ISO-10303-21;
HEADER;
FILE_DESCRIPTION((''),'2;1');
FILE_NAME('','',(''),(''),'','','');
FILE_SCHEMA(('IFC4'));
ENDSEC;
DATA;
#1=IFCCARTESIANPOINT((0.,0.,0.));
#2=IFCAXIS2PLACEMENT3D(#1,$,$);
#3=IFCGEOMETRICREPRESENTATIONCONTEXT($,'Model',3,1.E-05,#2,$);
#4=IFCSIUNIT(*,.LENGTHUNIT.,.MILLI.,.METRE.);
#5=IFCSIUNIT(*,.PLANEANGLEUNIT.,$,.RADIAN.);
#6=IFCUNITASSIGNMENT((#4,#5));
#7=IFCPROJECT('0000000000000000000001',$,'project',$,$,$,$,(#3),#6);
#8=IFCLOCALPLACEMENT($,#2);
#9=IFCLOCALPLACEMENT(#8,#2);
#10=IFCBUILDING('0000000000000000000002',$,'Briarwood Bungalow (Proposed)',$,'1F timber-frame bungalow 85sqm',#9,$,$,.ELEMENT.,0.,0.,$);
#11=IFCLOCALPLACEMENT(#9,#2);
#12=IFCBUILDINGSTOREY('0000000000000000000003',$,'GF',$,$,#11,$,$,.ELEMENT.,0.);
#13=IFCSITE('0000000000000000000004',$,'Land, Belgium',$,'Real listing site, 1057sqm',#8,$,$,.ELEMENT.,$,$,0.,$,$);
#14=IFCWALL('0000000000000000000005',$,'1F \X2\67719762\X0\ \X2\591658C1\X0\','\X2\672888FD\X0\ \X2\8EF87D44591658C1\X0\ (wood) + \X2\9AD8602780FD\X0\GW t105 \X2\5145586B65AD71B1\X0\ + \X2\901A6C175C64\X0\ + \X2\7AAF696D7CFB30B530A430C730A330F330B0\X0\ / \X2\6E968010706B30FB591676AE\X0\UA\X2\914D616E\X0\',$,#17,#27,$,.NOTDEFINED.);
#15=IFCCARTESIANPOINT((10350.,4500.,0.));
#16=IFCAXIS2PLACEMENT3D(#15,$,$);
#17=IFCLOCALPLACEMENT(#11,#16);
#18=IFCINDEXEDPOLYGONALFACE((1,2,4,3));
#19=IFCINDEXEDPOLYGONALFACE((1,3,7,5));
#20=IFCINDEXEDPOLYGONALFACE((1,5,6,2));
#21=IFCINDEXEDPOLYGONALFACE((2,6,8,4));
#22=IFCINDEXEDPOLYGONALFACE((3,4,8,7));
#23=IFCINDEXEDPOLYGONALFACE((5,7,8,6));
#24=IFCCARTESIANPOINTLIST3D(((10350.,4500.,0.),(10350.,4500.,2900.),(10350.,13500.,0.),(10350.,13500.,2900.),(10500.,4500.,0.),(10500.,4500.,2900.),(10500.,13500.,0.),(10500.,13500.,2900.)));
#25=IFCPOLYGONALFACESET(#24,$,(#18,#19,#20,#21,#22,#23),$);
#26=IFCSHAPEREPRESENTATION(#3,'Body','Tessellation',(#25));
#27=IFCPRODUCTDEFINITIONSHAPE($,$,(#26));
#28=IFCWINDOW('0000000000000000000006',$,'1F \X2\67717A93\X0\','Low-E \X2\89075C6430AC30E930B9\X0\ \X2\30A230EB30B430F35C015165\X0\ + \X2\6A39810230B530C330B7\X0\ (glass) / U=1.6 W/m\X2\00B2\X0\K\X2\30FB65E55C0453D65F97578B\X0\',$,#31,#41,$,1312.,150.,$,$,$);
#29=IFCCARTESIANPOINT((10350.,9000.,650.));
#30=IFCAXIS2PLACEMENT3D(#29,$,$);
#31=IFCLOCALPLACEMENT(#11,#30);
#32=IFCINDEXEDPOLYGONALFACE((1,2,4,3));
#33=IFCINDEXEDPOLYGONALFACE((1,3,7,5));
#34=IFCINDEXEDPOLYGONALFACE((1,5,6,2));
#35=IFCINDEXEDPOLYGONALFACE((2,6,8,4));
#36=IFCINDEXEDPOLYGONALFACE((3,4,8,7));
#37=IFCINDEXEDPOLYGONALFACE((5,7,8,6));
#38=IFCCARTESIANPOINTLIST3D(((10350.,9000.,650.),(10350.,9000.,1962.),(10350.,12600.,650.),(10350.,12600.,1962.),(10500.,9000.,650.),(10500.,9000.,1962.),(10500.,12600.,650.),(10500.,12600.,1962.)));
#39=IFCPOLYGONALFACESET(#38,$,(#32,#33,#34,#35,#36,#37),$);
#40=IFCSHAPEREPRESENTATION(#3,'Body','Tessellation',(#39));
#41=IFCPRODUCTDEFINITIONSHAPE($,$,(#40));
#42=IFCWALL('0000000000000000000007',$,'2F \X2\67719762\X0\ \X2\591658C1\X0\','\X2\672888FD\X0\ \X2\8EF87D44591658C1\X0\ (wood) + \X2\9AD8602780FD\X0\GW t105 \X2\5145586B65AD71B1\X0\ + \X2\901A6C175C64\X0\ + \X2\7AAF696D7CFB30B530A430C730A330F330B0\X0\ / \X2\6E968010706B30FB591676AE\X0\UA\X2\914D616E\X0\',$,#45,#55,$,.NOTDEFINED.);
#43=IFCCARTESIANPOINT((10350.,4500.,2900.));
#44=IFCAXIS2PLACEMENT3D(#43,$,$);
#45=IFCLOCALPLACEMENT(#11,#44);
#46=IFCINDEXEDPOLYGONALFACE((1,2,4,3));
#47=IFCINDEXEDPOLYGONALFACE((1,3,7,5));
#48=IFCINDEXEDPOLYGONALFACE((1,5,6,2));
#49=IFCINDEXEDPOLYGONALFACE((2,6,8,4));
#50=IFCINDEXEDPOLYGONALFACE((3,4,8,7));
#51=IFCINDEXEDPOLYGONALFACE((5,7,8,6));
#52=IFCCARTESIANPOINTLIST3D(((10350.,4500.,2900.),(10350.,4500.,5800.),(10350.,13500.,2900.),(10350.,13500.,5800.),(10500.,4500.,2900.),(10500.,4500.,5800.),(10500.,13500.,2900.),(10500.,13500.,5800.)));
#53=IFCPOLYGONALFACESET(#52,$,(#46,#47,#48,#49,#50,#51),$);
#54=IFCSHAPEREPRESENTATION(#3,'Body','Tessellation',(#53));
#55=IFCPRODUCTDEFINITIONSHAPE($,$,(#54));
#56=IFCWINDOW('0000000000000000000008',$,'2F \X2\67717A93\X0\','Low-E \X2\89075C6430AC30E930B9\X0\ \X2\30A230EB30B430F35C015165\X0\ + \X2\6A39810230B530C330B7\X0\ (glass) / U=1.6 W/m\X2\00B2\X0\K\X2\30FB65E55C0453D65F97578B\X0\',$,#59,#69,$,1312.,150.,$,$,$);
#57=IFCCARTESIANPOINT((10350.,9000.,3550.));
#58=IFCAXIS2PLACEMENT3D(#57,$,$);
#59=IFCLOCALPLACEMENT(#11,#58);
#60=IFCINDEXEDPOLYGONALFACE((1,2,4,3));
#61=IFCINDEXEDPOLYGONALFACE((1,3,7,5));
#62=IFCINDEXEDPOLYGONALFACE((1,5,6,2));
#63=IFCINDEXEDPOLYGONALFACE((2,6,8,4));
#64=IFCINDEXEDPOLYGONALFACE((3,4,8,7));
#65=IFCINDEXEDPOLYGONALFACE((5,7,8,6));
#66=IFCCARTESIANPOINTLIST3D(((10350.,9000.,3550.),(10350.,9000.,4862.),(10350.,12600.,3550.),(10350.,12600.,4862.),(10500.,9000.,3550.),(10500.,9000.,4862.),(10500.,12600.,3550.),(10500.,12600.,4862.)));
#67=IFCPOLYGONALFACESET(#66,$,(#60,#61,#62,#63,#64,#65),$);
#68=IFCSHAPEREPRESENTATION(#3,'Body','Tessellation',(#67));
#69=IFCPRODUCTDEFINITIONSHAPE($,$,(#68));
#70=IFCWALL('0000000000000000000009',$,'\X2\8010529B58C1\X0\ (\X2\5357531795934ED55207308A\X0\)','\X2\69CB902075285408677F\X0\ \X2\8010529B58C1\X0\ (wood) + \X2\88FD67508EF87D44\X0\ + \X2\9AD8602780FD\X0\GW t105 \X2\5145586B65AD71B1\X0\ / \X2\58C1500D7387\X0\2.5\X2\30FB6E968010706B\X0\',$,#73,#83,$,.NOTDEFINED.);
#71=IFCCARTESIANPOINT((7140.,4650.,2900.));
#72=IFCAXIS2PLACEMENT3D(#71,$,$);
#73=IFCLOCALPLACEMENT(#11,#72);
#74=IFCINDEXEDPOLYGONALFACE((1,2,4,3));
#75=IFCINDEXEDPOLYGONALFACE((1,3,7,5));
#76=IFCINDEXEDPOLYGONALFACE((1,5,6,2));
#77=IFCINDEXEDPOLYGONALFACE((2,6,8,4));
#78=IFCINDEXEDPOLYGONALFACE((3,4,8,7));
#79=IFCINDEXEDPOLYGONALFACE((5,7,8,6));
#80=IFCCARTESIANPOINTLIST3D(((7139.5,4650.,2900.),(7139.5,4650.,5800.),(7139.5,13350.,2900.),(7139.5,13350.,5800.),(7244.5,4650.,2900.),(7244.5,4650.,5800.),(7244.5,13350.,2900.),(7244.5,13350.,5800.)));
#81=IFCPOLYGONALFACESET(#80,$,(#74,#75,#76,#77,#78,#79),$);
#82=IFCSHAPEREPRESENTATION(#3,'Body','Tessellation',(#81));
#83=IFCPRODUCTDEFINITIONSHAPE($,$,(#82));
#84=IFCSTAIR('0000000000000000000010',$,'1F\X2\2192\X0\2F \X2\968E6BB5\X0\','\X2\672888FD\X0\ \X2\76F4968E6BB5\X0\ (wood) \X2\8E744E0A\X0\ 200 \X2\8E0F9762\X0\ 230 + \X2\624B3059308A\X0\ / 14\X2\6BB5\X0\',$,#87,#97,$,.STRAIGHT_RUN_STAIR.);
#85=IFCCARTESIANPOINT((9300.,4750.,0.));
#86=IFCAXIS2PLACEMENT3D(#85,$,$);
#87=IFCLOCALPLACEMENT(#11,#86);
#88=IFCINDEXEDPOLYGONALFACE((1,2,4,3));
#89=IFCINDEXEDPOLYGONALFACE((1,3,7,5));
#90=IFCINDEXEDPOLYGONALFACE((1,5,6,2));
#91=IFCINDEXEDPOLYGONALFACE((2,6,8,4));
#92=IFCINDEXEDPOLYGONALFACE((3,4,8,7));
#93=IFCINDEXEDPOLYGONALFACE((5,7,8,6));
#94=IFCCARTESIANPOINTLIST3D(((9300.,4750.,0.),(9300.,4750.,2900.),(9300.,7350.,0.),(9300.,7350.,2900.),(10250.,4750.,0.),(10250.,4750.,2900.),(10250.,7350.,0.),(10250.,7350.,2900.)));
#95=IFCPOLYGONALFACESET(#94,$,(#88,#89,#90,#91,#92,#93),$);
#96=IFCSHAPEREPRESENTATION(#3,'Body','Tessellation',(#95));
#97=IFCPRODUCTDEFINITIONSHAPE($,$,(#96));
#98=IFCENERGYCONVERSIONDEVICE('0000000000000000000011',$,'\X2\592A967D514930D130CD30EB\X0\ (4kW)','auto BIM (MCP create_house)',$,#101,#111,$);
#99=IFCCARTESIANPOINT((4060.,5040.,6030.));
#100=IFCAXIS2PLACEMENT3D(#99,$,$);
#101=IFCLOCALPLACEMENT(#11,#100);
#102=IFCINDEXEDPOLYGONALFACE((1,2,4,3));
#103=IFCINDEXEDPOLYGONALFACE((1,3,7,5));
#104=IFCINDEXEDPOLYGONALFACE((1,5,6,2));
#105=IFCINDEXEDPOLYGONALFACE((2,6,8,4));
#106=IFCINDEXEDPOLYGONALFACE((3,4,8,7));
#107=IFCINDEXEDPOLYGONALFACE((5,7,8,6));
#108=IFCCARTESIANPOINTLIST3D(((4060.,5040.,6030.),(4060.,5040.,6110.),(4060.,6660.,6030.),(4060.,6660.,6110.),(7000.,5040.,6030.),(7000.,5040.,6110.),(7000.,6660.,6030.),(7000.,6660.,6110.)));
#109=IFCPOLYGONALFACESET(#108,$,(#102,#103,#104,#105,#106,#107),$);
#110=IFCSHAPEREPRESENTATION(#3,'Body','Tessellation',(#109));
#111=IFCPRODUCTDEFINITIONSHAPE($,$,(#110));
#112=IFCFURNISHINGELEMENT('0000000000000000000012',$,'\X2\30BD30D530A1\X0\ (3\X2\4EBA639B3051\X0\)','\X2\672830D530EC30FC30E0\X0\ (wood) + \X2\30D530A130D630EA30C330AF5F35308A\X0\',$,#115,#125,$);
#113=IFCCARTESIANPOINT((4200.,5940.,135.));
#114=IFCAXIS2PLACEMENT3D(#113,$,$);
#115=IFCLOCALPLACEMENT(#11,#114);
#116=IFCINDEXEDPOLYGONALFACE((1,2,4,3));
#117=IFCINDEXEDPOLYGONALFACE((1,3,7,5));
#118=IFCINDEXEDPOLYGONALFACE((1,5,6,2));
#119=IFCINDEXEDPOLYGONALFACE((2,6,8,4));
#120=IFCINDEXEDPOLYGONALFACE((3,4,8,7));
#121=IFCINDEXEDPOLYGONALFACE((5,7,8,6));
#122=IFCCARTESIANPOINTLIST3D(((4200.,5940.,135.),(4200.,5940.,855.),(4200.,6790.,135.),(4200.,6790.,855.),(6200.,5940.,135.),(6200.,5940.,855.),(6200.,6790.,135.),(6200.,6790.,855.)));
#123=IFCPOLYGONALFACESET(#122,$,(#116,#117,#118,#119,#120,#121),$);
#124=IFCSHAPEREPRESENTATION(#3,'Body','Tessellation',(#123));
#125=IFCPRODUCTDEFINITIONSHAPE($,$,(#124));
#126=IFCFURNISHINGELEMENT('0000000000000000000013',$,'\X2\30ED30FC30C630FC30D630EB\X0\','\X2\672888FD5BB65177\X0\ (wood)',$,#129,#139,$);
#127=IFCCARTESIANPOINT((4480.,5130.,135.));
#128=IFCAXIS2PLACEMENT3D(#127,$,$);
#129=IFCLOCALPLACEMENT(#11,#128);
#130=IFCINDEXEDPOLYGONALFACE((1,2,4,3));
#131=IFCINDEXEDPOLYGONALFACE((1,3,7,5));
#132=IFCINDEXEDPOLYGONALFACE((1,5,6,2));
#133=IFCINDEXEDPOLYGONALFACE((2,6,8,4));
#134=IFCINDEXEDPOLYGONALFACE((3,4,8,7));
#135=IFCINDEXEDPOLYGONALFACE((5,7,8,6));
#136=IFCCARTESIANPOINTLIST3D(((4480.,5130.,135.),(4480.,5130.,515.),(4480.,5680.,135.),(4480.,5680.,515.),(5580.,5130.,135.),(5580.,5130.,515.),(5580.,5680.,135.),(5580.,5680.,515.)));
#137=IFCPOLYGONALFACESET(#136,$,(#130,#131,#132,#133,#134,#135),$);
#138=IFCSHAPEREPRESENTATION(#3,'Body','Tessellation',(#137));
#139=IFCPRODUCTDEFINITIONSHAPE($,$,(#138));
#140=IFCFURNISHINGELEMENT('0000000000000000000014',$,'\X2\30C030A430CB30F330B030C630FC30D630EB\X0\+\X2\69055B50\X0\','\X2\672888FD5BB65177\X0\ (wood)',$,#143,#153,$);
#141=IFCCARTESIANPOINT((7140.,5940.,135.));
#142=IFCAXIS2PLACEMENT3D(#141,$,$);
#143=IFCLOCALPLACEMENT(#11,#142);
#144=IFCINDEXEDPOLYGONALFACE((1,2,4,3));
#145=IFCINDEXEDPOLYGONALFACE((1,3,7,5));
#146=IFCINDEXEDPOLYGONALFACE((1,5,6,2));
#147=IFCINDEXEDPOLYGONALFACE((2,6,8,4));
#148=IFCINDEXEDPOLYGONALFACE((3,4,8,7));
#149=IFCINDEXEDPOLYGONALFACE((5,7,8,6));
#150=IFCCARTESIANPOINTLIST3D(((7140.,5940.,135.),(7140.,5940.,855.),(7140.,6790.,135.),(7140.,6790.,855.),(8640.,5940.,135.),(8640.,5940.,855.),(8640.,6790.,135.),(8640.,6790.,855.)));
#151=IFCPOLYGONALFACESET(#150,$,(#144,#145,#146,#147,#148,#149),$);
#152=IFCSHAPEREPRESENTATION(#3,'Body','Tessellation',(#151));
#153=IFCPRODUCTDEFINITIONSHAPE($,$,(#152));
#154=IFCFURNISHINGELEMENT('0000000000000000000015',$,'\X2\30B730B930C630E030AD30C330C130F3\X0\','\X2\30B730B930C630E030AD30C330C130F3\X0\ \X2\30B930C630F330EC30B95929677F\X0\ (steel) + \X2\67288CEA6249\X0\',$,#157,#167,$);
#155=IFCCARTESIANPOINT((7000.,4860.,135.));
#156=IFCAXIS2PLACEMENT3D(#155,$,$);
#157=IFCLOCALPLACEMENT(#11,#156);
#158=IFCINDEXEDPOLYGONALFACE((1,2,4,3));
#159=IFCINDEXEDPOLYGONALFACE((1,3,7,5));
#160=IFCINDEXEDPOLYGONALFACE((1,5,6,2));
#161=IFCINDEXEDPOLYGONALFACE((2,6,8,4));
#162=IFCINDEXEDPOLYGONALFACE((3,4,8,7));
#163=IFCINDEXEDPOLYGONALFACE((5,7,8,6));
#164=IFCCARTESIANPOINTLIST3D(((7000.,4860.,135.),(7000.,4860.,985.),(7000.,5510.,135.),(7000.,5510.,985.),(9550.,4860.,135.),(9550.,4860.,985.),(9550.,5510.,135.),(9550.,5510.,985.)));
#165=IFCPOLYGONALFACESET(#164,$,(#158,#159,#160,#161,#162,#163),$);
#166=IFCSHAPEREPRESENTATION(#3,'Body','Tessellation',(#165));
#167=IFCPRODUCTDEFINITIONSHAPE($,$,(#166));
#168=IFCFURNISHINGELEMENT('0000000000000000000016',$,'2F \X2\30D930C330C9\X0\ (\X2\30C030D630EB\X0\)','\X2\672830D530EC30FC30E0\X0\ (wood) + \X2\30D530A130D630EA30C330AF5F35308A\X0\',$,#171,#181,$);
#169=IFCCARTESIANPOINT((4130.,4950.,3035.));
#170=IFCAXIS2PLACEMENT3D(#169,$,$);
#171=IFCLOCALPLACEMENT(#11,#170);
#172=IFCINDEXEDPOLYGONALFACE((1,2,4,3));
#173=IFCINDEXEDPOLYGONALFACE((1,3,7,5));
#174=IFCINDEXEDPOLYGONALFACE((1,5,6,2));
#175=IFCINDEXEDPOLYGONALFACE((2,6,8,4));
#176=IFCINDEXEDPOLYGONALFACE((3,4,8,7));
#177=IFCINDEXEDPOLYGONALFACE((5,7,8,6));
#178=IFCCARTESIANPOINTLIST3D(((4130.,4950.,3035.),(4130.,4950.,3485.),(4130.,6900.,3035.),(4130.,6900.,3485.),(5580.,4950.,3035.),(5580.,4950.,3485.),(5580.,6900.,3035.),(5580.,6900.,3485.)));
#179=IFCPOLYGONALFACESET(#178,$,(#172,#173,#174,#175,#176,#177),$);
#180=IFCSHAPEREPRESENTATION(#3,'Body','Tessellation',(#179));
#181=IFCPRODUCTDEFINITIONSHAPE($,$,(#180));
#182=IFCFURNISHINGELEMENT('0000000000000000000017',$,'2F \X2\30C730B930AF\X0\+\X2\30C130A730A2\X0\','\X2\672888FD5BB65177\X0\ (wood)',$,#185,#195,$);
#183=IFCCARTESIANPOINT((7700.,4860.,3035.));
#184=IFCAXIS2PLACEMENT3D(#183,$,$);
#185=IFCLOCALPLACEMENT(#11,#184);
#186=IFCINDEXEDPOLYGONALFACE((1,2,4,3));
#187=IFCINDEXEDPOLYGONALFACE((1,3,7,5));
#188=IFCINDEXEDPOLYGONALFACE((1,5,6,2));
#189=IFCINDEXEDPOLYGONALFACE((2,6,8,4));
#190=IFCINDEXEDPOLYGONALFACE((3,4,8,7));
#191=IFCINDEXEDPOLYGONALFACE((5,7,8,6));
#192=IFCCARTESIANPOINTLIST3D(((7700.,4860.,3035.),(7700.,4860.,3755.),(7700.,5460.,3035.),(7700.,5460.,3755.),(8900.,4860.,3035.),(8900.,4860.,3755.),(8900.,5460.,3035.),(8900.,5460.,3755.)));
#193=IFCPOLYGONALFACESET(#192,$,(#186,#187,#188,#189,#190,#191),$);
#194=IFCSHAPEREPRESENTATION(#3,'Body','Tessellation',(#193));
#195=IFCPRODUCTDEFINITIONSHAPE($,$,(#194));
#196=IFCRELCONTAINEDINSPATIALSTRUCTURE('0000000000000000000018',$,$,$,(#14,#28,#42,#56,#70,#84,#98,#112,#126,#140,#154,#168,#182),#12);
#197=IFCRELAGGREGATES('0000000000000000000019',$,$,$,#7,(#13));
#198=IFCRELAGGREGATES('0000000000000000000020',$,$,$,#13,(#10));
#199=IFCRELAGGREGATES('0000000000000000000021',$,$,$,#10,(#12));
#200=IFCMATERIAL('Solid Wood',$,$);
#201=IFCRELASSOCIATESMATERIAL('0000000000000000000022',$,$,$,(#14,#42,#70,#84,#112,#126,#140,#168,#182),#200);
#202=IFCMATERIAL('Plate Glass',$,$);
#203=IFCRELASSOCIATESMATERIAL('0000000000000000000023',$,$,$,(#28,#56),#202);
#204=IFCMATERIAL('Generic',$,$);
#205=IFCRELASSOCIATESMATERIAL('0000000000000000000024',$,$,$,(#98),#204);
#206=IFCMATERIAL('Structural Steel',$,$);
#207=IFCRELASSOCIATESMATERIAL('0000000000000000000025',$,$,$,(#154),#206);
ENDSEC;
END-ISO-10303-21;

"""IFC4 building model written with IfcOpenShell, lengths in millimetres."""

from ifc_helpers import new_model, si_unit, frame, frame_2d, origin, place, context, project, spatial, rectangle, extrude, material, element, fill, save


model = new_model("IFC4")

# Units and contexts
model_context = context("Model", 3, precision=1e-05, world=origin())
ifc_project = project(units=[si_unit("LENGTHUNIT", "METRE", prefix="MILLI"), si_unit("PLANEANGLEUNIT", "RADIAN")], contexts=[model_context])

# Site, building, storey
site_placement = place(None, origin())
site = spatial("IfcSite", under=ifc_project, at=site_placement, Name="Land, Belgium", ObjectType="Real listing site, 1057sqm", CompositionType="ELEMENT", RefElevation=0.0)
building_placement = place(site_placement, origin())
building = spatial("IfcBuilding", under=site, at=building_placement, Name="Briarwood Bungalow (Proposed)", ObjectType="1F timber-frame bungalow 85sqm", CompositionType="ELEMENT", ElevationOfRefHeight=0.0, ElevationOfTerrain=0.0)
storey_placement = place(building_placement, origin())
storey = spatial("IfcBuildingStorey", under=building, at=storey_placement, Name="GF", CompositionType="ELEMENT", Elevation=0.0)

# Wall, opening, window
ifc_material_1 = material(Name="Solid Wood")
wall_1_placement = place(storey_placement, frame((10350.0, 4500.0, 0.0)))
wall_1 = element("IfcWall", 1, at=wall_1_placement, inside=storey, material=ifc_material_1, Name="1F 東面 外壁", Description="木製 軸組外壁 (wood) + 高性能GW t105 充填断熱 + 通気層 + 窯業系サイディング / 準耐火・外皮UA配慮", PredefinedType="NOTDEFINED", context=model_context, shape_type="SweptSolid", body=[
    extrude(rectangle(XDim=150.0, YDim=9000.0, at=frame_2d((75.0, 4500.0))), frame((10350.0, 4500.0, 0.0)), (0.0, 0.0, 1.0), 2900.0),
])
opening_1_placement = place(storey_placement, frame((10350.0, 9000.0, 650.0)))
opening_1 = element("IfcOpeningElement", 2, at=opening_1_placement, cuts=wall_1, PredefinedType="NOTDEFINED", context=model_context, shape_type="SweptSolid", body=[
    extrude(rectangle(XDim=150.0, YDim=3600.0, at=frame_2d((75.0, 1800.0))), frame((10350.0, 9000.0, 650.0)), (0.0, 0.0, 1.0), 1312.0),
])
ifc_material_2 = material(Name="Plate Glass")
window_1_placement = place(storey_placement, frame((10350.0, 9000.0, 650.0)))
window_1 = element("IfcWindow", 3, at=window_1_placement, inside=storey, material=ifc_material_2, Name="1F 東窓", Description="Low-E 複層ガラス アルゴン封入 + 樹脂サッシ (glass) / U=1.6 W/m²K・日射取得型", OverallHeight=1312.0, OverallWidth=150.0, context=model_context, shape_type="SweptSolid", body=[
    extrude(rectangle(XDim=150.0, YDim=3600.0, at=frame_2d((75.0, 1800.0))), frame((10350.0, 9000.0, 650.0)), (0.0, 0.0, 1.0), 1312.0),
])
fill(opening_1, window_1)

# Wall, opening, window
wall_2_placement = place(storey_placement, frame((10350.0, 4500.0, 2900.0)))
wall_2 = element("IfcWall", 4, at=wall_2_placement, inside=storey, material=ifc_material_1, Name="2F 東面 外壁", Description="木製 軸組外壁 (wood) + 高性能GW t105 充填断熱 + 通気層 + 窯業系サイディング / 準耐火・外皮UA配慮", PredefinedType="NOTDEFINED", context=model_context, shape_type="SweptSolid", body=[
    extrude(rectangle(XDim=150.0, YDim=9000.0, at=frame_2d((75.0, 4500.0))), frame((10350.0, 4500.0, 2900.0)), (0.0, 0.0, 1.0), 2900.0),
])
opening_2_placement = place(storey_placement, frame((10350.0, 9000.0, 3550.0)))
opening_2 = element("IfcOpeningElement", 5, at=opening_2_placement, cuts=wall_2, PredefinedType="NOTDEFINED", context=model_context, shape_type="SweptSolid", body=[
    extrude(rectangle(XDim=150.0, YDim=3600.0, at=frame_2d((75.0, 1800.0))), frame((10350.0, 9000.0, 3550.0)), (0.0, 0.0, 1.0), 1312.0),
])
window_2_placement = place(storey_placement, frame((10350.0, 9000.0, 3550.0)))
window_2 = element("IfcWindow", 6, at=window_2_placement, inside=storey, material=ifc_material_2, Name="2F 東窓", Description="Low-E 複層ガラス アルゴン封入 + 樹脂サッシ (glass) / U=1.6 W/m²K・日射取得型", OverallHeight=1312.0, OverallWidth=150.0, context=model_context, shape_type="SweptSolid", body=[
    extrude(rectangle(XDim=150.0, YDim=3600.0, at=frame_2d((75.0, 1800.0))), frame((10350.0, 9000.0, 3550.0)), (0.0, 0.0, 1.0), 1312.0),
])
fill(opening_2, window_2)

# Wall
wall_3_placement = place(storey_placement, frame((7140.0, 4650.0, 2900.0)))
element("IfcWall", 7, at=wall_3_placement, inside=storey, material=ifc_material_1, Name="耐力壁 (南北間仕切り)", Description="構造用合板 耐力壁 (wood) + 製材軸組 + 高性能GW t105 充填断熱 / 壁倍率2.5・準耐火", PredefinedType="NOTDEFINED", context=model_context, shape_type="SweptSolid", body=[
    extrude(rectangle(XDim=105.0, YDim=8700.0, at=frame_2d((52.0, 4350.0))), frame((7140.0, 4650.0, 2900.0)), (0.0, 0.0, 1.0), 2900.0),
])

# Stair
stair_placement = place(storey_placement, frame((9300.0, 4750.0, 0.0)))
element("IfcStair", 8, at=stair_placement, inside=storey, material=ifc_material_1, Name="1F→2F 階段", Description="木製 直階段 (wood) 蹴上 200 踏面 230 + 手すり / 14段", PredefinedType="STRAIGHT_RUN_STAIR", context=model_context, shape_type="SweptSolid", body=[
    extrude(rectangle(XDim=950.0, YDim=2600.0, at=frame_2d((475.0, 1300.0))), frame((9300.0, 4750.0, 0.0)), (0.0, 0.0, 1.0), 2900.0),
])

# Energy conversion device
ifc_material_3 = material(Name="Generic")
energy_conversion_device_placement = place(storey_placement, frame((4060.0, 5040.0, 6030.0)))
element("IfcEnergyConversionDevice", 9, at=energy_conversion_device_placement, inside=storey, material=ifc_material_3, Name="太陽光パネル (4kW)", Description="auto BIM (MCP create_house)", context=model_context, shape_type="SweptSolid", body=[
    extrude(rectangle(XDim=2940.0, YDim=1620.0, at=frame_2d((1470.0, 810.0))), frame((4060.0, 5040.0, 6030.0)), (0.0, 0.0, 1.0), 80.0),
])

# Furnishing elements
furnishing_1_placement = place(storey_placement, frame((4200.0, 5940.0, 135.0)))
element("IfcFurnishingElement", 10, at=furnishing_1_placement, inside=storey, material=ifc_material_1, Name="ソファ (3人掛け)", Description="木フレーム (wood) + ファブリック張り", context=model_context, shape_type="SweptSolid", body=[
    extrude(rectangle(XDim=2000.0, YDim=850.0, at=frame_2d((1000.0, 425.0))), frame((4200.0, 5940.0, 135.0)), (0.0, 0.0, 1.0), 720.0),
])
furnishing_2_placement = place(storey_placement, frame((4480.0, 5130.0, 135.0)))
element("IfcFurnishingElement", 11, at=furnishing_2_placement, inside=storey, material=ifc_material_1, Name="ローテーブル", Description="木製家具 (wood)", context=model_context, shape_type="SweptSolid", body=[
    extrude(rectangle(XDim=1100.0, YDim=550.0, at=frame_2d((550.0, 275.0))), frame((4480.0, 5130.0, 135.0)), (0.0, 0.0, 1.0), 380.0),
])
furnishing_3_placement = place(storey_placement, frame((7140.0, 5940.0, 135.0)))
element("IfcFurnishingElement", 12, at=furnishing_3_placement, inside=storey, material=ifc_material_1, Name="ダイニングテーブル+椅子", Description="木製家具 (wood)", context=model_context, shape_type="SweptSolid", body=[
    extrude(rectangle(XDim=1500.0, YDim=850.0, at=frame_2d((750.0, 425.0))), frame((7140.0, 5940.0, 135.0)), (0.0, 0.0, 1.0), 720.0),
])
ifc_material_4 = material(Name="Structural Steel")
furnishing_4_placement = place(storey_placement, frame((7000.0, 4860.0, 135.0)))
element("IfcFurnishingElement", 13, at=furnishing_4_placement, inside=storey, material=ifc_material_4, Name="システムキッチン", Description="システムキッチン ステンレス天板 (steel) + 木質扉", context=model_context, shape_type="SweptSolid", body=[
    extrude(rectangle(XDim=2550.0, YDim=650.0, at=frame_2d((1275.0, 325.0))), frame((7000.0, 4860.0, 135.0)), (0.0, 0.0, 1.0), 850.0),
])
furnishing_5_placement = place(storey_placement, frame((4130.0, 4950.0, 3035.0)))
element("IfcFurnishingElement", 14, at=furnishing_5_placement, inside=storey, material=ifc_material_1, Name="2F ベッド (ダブル)", Description="木フレーム (wood) + ファブリック張り", context=model_context, shape_type="SweptSolid", body=[
    extrude(rectangle(XDim=1450.0, YDim=1950.0, at=frame_2d((725.0, 975.0))), frame((4130.0, 4950.0, 3035.0)), (0.0, 0.0, 1.0), 450.0),
])
furnishing_6_placement = place(storey_placement, frame((7700.0, 4860.0, 3035.0)))
element("IfcFurnishingElement", 15, at=furnishing_6_placement, inside=storey, material=ifc_material_1, Name="2F デスク+チェア", Description="木製家具 (wood)", context=model_context, shape_type="SweptSolid", body=[
    extrude(rectangle(XDim=1200.0, YDim=600.0, at=frame_2d((600.0, 300.0))), frame((7700.0, 4860.0, 3035.0)), (0.0, 0.0, 1.0), 720.0),
])

save(model, "model.ifc")
